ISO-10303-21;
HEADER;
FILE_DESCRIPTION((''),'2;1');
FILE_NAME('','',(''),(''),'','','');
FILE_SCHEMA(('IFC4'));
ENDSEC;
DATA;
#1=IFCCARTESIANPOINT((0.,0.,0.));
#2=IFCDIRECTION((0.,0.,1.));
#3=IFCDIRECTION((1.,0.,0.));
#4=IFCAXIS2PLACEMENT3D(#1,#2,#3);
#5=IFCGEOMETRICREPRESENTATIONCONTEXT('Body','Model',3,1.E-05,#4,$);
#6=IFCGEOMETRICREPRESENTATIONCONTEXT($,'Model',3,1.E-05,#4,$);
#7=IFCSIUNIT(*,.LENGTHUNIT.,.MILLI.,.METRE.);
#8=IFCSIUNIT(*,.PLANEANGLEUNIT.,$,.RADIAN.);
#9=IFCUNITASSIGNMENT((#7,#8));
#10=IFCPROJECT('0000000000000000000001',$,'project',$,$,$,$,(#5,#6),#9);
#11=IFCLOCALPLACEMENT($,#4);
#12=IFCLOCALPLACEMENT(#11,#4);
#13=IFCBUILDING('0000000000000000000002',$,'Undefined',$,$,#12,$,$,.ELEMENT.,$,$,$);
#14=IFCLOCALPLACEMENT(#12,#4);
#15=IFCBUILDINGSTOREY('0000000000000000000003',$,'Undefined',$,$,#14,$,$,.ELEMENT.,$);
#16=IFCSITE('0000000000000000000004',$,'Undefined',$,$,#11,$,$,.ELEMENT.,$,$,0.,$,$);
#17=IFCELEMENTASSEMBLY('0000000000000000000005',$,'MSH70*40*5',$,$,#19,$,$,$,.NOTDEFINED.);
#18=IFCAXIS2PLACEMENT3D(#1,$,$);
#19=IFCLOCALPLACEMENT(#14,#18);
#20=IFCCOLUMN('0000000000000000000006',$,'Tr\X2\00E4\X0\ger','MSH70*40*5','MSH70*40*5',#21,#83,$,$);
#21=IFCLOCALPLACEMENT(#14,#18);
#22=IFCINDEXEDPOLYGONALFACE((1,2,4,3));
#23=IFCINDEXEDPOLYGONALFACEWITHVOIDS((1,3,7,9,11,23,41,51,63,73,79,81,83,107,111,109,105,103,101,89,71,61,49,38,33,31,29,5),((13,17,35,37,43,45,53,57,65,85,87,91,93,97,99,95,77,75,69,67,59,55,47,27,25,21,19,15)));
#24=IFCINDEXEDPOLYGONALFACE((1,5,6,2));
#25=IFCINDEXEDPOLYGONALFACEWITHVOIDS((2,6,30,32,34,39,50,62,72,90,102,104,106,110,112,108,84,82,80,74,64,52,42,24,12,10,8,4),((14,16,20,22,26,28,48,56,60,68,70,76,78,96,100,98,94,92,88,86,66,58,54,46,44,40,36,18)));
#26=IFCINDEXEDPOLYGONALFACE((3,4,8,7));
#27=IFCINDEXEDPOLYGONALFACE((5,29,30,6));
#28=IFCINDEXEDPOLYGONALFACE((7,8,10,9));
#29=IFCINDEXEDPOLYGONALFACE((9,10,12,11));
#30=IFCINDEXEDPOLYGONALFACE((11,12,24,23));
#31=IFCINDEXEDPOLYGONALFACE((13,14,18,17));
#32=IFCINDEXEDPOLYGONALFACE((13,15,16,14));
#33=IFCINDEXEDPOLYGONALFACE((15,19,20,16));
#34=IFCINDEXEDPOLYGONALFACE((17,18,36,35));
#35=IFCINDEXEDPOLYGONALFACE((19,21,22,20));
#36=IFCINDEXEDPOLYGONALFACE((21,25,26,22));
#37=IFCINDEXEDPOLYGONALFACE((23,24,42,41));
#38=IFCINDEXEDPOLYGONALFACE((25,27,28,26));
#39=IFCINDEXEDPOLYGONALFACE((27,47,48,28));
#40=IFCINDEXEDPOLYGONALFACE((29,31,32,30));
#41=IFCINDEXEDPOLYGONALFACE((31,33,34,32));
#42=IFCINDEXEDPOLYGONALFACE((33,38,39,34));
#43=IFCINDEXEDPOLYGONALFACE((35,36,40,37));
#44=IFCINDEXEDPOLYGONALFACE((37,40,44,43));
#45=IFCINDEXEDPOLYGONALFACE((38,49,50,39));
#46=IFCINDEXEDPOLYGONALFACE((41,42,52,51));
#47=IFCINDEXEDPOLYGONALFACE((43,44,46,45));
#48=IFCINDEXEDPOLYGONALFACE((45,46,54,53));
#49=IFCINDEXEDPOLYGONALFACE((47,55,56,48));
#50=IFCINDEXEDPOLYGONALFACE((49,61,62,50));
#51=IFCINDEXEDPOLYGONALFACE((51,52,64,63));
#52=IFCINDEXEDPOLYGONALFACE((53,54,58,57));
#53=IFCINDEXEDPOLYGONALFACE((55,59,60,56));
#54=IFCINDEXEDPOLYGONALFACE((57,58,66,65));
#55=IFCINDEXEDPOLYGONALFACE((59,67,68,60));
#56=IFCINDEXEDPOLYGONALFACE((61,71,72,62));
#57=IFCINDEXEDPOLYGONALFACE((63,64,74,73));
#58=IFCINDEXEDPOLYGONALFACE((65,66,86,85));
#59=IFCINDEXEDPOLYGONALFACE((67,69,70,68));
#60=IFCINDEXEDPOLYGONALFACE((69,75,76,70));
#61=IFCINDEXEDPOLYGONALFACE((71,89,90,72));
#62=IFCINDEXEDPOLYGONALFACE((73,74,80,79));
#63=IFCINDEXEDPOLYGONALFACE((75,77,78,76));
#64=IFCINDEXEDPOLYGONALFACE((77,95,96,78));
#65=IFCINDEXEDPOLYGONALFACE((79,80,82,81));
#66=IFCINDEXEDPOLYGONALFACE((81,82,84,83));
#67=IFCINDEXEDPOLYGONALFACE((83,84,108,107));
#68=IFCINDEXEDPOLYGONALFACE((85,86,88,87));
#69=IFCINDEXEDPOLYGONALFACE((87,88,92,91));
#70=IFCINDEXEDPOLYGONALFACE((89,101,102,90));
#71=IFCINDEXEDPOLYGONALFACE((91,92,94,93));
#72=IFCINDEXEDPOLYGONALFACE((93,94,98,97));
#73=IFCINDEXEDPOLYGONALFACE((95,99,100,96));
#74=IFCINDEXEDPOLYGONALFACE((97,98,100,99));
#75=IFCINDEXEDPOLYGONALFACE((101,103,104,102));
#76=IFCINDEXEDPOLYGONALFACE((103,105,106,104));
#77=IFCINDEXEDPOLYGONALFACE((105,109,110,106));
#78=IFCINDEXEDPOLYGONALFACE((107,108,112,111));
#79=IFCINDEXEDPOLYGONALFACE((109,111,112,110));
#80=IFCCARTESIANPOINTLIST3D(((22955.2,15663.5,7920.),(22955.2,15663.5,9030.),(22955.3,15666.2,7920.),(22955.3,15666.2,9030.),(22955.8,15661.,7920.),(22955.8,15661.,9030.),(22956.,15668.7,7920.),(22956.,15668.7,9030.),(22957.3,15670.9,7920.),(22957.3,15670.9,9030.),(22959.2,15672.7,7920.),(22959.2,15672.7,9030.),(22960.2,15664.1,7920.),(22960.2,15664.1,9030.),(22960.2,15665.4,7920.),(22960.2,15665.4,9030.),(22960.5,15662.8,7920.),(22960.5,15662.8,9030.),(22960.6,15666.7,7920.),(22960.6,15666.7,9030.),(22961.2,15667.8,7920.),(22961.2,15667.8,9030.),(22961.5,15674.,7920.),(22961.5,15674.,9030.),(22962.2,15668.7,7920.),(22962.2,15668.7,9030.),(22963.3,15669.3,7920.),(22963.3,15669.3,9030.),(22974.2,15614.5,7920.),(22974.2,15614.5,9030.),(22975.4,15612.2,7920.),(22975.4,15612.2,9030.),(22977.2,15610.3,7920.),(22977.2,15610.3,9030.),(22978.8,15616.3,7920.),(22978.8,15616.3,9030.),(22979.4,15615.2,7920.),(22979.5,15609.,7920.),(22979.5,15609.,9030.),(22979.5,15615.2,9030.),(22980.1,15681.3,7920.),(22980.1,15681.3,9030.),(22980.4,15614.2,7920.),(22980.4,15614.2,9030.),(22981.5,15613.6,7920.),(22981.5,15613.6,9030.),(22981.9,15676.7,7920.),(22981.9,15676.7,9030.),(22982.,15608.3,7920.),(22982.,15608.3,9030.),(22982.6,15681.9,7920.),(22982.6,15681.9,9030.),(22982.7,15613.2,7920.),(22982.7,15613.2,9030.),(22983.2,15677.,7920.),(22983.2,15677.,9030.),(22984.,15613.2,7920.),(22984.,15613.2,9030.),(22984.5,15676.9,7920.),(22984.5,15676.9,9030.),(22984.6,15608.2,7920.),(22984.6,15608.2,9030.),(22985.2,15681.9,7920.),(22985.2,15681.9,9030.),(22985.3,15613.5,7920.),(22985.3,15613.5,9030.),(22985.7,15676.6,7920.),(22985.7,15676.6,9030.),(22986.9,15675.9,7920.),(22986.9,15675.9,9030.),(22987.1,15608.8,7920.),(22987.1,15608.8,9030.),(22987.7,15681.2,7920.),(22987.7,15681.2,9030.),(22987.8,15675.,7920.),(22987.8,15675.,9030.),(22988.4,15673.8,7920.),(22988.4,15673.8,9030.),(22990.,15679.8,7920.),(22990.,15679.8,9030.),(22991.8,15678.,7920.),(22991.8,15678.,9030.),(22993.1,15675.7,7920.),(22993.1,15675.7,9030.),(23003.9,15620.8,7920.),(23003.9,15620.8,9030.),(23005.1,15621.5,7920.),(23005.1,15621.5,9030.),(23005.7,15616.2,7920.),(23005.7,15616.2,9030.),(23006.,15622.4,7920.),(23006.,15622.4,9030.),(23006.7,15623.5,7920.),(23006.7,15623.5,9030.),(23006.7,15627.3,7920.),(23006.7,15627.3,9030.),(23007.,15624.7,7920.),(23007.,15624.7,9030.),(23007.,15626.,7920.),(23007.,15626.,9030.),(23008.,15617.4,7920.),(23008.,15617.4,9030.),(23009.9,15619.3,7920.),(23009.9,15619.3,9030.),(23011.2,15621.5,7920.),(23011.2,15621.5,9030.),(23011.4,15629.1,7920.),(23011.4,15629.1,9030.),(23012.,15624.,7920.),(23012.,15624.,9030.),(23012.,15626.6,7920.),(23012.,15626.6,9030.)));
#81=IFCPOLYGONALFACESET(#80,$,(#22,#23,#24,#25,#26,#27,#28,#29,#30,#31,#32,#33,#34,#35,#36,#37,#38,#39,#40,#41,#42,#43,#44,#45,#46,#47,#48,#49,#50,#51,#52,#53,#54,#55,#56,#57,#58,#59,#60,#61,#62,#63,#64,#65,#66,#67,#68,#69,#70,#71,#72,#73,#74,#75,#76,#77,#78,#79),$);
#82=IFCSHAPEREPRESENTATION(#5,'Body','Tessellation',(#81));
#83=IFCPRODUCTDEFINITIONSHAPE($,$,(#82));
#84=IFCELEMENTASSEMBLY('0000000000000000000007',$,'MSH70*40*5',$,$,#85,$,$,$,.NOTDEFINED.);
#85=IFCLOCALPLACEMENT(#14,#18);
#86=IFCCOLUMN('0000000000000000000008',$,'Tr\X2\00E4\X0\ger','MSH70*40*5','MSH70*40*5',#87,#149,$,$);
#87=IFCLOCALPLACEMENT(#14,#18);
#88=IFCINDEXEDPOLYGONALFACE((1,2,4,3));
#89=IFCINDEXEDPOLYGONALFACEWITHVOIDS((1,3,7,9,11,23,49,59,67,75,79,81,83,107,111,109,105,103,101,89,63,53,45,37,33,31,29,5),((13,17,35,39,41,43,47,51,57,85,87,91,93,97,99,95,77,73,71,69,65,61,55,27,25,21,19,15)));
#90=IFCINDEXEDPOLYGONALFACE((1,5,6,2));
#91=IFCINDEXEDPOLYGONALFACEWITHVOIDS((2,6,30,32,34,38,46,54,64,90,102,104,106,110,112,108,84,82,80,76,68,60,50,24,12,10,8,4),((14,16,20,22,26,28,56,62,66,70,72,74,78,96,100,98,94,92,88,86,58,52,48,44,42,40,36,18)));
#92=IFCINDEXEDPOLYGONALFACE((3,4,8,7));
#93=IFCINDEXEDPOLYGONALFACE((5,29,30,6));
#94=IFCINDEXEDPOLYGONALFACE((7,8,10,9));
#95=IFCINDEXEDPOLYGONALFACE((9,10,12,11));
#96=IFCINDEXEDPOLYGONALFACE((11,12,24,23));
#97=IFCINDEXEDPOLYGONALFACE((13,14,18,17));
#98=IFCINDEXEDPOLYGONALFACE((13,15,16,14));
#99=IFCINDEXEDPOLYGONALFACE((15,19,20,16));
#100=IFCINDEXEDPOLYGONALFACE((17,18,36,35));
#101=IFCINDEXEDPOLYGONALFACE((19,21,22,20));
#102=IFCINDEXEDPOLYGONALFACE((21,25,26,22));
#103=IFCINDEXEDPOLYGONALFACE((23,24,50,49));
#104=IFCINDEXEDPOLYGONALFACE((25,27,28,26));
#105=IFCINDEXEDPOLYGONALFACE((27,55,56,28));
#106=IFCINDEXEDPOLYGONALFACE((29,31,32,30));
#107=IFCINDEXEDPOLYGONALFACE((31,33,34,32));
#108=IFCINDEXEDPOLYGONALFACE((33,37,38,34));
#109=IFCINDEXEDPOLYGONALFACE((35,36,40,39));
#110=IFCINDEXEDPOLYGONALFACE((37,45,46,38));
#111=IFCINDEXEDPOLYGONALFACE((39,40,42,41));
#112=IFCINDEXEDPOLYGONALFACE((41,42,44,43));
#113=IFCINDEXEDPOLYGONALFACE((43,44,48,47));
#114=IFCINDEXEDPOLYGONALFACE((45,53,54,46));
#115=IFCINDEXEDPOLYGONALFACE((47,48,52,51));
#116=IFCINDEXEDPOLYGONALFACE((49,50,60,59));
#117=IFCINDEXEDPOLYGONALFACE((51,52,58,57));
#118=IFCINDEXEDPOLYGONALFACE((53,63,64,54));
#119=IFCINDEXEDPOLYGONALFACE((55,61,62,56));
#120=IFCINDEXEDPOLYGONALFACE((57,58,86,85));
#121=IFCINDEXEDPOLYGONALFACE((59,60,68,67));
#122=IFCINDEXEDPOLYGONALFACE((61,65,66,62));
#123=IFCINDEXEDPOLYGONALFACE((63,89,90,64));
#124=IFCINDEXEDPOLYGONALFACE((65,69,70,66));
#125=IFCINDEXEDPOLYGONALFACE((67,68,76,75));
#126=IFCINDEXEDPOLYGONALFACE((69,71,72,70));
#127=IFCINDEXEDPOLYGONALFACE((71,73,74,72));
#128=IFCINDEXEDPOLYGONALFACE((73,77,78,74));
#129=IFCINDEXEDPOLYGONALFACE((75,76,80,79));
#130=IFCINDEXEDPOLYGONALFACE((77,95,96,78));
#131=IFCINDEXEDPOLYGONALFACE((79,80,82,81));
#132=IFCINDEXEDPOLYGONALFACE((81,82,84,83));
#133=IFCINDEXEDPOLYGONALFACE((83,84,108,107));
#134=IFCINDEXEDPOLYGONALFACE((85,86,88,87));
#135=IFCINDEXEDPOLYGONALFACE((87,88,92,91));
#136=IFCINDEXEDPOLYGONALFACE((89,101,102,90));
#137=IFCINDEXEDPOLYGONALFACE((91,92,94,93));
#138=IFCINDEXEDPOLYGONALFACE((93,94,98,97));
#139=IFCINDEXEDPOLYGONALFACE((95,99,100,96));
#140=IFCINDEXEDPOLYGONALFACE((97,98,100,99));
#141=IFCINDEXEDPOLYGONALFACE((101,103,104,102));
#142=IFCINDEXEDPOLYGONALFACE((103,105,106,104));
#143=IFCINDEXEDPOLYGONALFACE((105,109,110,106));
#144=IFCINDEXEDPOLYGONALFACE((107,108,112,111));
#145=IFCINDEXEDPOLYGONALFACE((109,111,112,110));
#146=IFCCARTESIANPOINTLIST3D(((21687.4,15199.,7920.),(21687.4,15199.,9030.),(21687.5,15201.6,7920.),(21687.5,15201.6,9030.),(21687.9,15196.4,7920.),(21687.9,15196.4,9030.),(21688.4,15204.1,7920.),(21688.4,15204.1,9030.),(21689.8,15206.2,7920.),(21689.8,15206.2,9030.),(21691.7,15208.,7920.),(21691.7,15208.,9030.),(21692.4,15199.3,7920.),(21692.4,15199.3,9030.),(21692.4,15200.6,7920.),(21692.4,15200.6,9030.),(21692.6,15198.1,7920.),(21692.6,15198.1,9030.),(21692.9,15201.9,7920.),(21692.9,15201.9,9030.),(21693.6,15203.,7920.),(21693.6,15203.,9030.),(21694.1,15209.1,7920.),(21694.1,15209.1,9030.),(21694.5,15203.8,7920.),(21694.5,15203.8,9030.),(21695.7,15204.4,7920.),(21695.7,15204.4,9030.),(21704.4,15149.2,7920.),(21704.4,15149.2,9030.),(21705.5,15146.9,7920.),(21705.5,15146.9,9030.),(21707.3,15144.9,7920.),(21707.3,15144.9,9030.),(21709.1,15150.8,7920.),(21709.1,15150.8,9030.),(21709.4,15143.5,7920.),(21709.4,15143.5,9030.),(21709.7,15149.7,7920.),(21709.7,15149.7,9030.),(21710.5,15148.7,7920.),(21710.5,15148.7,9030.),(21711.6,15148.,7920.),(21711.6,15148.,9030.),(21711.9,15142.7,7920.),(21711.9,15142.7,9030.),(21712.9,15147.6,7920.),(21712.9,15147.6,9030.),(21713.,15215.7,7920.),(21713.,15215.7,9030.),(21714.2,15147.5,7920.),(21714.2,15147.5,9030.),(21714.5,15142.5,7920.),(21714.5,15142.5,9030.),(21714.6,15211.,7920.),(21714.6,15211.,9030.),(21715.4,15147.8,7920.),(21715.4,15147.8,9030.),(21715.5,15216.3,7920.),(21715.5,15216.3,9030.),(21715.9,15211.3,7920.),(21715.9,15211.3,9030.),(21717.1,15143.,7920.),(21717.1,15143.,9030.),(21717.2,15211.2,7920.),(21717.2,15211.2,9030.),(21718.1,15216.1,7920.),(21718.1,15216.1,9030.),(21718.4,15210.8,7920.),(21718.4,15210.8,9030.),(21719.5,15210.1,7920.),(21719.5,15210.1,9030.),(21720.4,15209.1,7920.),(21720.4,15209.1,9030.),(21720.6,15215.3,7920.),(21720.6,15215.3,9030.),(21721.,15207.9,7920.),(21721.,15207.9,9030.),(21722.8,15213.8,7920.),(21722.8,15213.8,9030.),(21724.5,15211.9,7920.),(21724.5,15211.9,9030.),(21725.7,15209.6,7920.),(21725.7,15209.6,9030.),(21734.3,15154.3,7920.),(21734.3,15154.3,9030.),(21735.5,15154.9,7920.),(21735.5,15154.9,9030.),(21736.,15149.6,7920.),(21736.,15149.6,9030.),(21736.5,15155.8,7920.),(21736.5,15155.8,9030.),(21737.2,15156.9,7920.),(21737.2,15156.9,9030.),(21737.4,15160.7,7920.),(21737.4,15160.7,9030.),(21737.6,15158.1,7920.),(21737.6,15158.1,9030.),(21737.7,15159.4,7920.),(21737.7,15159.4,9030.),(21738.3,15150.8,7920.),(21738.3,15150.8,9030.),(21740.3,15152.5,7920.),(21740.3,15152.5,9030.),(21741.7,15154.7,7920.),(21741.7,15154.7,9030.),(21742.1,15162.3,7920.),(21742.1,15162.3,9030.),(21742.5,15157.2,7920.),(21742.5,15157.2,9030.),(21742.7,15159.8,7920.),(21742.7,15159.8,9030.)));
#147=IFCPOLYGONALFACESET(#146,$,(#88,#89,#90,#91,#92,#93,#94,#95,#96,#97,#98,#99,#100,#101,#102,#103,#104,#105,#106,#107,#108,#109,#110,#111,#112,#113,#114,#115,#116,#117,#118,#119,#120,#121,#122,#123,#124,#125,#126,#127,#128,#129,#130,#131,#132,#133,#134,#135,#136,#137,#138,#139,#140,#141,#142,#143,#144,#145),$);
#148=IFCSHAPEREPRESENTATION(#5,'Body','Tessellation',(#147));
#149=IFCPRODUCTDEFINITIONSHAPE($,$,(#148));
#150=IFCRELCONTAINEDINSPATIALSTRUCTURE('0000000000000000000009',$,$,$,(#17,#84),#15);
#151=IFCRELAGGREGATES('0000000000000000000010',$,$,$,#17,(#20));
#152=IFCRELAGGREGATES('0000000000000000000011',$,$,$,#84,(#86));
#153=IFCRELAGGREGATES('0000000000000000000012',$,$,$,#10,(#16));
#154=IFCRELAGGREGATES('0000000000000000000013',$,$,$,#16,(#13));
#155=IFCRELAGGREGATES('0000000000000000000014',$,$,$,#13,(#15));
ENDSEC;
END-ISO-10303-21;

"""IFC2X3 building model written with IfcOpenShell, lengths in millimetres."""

from ifc_helpers import new_model, si_unit, frame, origin_with_axes, origin_2d_with_axis, place, context, project, spatial, hollow_rectangle, extrude, element, aggregate, save


model = new_model("IFC2X3")

# Units and contexts
model_context_1 = context("Model", 3, precision=1e-05, world=origin_with_axes(), identifier="Body")
model_context_2 = context("Model", 3, precision=1e-05, world=origin_with_axes())
ifc_project = project(units=[si_unit("LENGTHUNIT", "METRE", prefix="MILLI"), si_unit("PLANEANGLEUNIT", "RADIAN")], contexts=[model_context_1, model_context_2])

# Site, building, storey
site_placement = place(None, origin_with_axes())
site = spatial("IfcSite", under=ifc_project, at=site_placement, Name="Undefined", CompositionType="ELEMENT", RefElevation=0.0)
building_placement = place(site_placement, origin_with_axes())
building = spatial("IfcBuilding", under=site, at=building_placement, Name="Undefined", CompositionType="ELEMENT")
storey_placement = place(building_placement, origin_with_axes())
storey = spatial("IfcBuildingStorey", under=building, at=storey_placement, Name="Undefined", CompositionType="ELEMENT")

# Element assemblies, columns
assembly_1 = element("IfcElementAssembly", 1, inside=storey, Name="MSH70*40*5", PredefinedType="NOTDEFINED")
column_1_placement = place(storey_placement, frame((22983.6, 15645.1, 7920.0), z_axis=(0.0, 0.0, 1.0), x_axis=(1.0, 0.0, 0.0)))
column_1 = element("IfcColumn", 2, at=column_1_placement, Name="Träger", Description="MSH70*40*5", ObjectType="MSH70*40*5", context=model_context_1, shape_type="SweptSolid", body=[
    extrude(hollow_rectangle(XDim=40.0, YDim=70.0, WallThickness=5.0, InnerFilletRadius=5.0, OuterFilletRadius=10.0, at=origin_2d_with_axis()), frame((0.0, 0.0, 1110.0), z_axis=(0.0, 0.0, -1.0), x_axis=(-0.930417, -0.366502, 0.000005)), (0.0, 0.0, 1.0), 1110.0),
])
aggregate(assembly_1, [column_1])
assembly_2 = element("IfcElementAssembly", 3, inside=storey, Name="MSH70*40*5", PredefinedType="NOTDEFINED")
column_2_placement = place(storey_placement, frame((21715.0, 15179.4, 7920.0), z_axis=(0.0, 0.0, 1.0), x_axis=(1.0, 0.0, 0.0)))
column_2 = element("IfcColumn", 4, at=column_2_placement, Name="Träger", Description="MSH70*40*5", ObjectType="MSH70*40*5", context=model_context_1, shape_type="SweptSolid", body=[
    extrude(hollow_rectangle(XDim=40.0, YDim=70.0, WallThickness=5.0, InnerFilletRadius=5.0, OuterFilletRadius=10.0, at=origin_2d_with_axis()), frame((0.0, 0.0, 1110.0), z_axis=(0.0, 0.0, -1.0), x_axis=(-0.944376, -0.328867, 0.000005)), (0.0, 0.0, 1.0), 1110.0),
])
aggregate(assembly_2, [column_2])

save(model, "model.ifc")
